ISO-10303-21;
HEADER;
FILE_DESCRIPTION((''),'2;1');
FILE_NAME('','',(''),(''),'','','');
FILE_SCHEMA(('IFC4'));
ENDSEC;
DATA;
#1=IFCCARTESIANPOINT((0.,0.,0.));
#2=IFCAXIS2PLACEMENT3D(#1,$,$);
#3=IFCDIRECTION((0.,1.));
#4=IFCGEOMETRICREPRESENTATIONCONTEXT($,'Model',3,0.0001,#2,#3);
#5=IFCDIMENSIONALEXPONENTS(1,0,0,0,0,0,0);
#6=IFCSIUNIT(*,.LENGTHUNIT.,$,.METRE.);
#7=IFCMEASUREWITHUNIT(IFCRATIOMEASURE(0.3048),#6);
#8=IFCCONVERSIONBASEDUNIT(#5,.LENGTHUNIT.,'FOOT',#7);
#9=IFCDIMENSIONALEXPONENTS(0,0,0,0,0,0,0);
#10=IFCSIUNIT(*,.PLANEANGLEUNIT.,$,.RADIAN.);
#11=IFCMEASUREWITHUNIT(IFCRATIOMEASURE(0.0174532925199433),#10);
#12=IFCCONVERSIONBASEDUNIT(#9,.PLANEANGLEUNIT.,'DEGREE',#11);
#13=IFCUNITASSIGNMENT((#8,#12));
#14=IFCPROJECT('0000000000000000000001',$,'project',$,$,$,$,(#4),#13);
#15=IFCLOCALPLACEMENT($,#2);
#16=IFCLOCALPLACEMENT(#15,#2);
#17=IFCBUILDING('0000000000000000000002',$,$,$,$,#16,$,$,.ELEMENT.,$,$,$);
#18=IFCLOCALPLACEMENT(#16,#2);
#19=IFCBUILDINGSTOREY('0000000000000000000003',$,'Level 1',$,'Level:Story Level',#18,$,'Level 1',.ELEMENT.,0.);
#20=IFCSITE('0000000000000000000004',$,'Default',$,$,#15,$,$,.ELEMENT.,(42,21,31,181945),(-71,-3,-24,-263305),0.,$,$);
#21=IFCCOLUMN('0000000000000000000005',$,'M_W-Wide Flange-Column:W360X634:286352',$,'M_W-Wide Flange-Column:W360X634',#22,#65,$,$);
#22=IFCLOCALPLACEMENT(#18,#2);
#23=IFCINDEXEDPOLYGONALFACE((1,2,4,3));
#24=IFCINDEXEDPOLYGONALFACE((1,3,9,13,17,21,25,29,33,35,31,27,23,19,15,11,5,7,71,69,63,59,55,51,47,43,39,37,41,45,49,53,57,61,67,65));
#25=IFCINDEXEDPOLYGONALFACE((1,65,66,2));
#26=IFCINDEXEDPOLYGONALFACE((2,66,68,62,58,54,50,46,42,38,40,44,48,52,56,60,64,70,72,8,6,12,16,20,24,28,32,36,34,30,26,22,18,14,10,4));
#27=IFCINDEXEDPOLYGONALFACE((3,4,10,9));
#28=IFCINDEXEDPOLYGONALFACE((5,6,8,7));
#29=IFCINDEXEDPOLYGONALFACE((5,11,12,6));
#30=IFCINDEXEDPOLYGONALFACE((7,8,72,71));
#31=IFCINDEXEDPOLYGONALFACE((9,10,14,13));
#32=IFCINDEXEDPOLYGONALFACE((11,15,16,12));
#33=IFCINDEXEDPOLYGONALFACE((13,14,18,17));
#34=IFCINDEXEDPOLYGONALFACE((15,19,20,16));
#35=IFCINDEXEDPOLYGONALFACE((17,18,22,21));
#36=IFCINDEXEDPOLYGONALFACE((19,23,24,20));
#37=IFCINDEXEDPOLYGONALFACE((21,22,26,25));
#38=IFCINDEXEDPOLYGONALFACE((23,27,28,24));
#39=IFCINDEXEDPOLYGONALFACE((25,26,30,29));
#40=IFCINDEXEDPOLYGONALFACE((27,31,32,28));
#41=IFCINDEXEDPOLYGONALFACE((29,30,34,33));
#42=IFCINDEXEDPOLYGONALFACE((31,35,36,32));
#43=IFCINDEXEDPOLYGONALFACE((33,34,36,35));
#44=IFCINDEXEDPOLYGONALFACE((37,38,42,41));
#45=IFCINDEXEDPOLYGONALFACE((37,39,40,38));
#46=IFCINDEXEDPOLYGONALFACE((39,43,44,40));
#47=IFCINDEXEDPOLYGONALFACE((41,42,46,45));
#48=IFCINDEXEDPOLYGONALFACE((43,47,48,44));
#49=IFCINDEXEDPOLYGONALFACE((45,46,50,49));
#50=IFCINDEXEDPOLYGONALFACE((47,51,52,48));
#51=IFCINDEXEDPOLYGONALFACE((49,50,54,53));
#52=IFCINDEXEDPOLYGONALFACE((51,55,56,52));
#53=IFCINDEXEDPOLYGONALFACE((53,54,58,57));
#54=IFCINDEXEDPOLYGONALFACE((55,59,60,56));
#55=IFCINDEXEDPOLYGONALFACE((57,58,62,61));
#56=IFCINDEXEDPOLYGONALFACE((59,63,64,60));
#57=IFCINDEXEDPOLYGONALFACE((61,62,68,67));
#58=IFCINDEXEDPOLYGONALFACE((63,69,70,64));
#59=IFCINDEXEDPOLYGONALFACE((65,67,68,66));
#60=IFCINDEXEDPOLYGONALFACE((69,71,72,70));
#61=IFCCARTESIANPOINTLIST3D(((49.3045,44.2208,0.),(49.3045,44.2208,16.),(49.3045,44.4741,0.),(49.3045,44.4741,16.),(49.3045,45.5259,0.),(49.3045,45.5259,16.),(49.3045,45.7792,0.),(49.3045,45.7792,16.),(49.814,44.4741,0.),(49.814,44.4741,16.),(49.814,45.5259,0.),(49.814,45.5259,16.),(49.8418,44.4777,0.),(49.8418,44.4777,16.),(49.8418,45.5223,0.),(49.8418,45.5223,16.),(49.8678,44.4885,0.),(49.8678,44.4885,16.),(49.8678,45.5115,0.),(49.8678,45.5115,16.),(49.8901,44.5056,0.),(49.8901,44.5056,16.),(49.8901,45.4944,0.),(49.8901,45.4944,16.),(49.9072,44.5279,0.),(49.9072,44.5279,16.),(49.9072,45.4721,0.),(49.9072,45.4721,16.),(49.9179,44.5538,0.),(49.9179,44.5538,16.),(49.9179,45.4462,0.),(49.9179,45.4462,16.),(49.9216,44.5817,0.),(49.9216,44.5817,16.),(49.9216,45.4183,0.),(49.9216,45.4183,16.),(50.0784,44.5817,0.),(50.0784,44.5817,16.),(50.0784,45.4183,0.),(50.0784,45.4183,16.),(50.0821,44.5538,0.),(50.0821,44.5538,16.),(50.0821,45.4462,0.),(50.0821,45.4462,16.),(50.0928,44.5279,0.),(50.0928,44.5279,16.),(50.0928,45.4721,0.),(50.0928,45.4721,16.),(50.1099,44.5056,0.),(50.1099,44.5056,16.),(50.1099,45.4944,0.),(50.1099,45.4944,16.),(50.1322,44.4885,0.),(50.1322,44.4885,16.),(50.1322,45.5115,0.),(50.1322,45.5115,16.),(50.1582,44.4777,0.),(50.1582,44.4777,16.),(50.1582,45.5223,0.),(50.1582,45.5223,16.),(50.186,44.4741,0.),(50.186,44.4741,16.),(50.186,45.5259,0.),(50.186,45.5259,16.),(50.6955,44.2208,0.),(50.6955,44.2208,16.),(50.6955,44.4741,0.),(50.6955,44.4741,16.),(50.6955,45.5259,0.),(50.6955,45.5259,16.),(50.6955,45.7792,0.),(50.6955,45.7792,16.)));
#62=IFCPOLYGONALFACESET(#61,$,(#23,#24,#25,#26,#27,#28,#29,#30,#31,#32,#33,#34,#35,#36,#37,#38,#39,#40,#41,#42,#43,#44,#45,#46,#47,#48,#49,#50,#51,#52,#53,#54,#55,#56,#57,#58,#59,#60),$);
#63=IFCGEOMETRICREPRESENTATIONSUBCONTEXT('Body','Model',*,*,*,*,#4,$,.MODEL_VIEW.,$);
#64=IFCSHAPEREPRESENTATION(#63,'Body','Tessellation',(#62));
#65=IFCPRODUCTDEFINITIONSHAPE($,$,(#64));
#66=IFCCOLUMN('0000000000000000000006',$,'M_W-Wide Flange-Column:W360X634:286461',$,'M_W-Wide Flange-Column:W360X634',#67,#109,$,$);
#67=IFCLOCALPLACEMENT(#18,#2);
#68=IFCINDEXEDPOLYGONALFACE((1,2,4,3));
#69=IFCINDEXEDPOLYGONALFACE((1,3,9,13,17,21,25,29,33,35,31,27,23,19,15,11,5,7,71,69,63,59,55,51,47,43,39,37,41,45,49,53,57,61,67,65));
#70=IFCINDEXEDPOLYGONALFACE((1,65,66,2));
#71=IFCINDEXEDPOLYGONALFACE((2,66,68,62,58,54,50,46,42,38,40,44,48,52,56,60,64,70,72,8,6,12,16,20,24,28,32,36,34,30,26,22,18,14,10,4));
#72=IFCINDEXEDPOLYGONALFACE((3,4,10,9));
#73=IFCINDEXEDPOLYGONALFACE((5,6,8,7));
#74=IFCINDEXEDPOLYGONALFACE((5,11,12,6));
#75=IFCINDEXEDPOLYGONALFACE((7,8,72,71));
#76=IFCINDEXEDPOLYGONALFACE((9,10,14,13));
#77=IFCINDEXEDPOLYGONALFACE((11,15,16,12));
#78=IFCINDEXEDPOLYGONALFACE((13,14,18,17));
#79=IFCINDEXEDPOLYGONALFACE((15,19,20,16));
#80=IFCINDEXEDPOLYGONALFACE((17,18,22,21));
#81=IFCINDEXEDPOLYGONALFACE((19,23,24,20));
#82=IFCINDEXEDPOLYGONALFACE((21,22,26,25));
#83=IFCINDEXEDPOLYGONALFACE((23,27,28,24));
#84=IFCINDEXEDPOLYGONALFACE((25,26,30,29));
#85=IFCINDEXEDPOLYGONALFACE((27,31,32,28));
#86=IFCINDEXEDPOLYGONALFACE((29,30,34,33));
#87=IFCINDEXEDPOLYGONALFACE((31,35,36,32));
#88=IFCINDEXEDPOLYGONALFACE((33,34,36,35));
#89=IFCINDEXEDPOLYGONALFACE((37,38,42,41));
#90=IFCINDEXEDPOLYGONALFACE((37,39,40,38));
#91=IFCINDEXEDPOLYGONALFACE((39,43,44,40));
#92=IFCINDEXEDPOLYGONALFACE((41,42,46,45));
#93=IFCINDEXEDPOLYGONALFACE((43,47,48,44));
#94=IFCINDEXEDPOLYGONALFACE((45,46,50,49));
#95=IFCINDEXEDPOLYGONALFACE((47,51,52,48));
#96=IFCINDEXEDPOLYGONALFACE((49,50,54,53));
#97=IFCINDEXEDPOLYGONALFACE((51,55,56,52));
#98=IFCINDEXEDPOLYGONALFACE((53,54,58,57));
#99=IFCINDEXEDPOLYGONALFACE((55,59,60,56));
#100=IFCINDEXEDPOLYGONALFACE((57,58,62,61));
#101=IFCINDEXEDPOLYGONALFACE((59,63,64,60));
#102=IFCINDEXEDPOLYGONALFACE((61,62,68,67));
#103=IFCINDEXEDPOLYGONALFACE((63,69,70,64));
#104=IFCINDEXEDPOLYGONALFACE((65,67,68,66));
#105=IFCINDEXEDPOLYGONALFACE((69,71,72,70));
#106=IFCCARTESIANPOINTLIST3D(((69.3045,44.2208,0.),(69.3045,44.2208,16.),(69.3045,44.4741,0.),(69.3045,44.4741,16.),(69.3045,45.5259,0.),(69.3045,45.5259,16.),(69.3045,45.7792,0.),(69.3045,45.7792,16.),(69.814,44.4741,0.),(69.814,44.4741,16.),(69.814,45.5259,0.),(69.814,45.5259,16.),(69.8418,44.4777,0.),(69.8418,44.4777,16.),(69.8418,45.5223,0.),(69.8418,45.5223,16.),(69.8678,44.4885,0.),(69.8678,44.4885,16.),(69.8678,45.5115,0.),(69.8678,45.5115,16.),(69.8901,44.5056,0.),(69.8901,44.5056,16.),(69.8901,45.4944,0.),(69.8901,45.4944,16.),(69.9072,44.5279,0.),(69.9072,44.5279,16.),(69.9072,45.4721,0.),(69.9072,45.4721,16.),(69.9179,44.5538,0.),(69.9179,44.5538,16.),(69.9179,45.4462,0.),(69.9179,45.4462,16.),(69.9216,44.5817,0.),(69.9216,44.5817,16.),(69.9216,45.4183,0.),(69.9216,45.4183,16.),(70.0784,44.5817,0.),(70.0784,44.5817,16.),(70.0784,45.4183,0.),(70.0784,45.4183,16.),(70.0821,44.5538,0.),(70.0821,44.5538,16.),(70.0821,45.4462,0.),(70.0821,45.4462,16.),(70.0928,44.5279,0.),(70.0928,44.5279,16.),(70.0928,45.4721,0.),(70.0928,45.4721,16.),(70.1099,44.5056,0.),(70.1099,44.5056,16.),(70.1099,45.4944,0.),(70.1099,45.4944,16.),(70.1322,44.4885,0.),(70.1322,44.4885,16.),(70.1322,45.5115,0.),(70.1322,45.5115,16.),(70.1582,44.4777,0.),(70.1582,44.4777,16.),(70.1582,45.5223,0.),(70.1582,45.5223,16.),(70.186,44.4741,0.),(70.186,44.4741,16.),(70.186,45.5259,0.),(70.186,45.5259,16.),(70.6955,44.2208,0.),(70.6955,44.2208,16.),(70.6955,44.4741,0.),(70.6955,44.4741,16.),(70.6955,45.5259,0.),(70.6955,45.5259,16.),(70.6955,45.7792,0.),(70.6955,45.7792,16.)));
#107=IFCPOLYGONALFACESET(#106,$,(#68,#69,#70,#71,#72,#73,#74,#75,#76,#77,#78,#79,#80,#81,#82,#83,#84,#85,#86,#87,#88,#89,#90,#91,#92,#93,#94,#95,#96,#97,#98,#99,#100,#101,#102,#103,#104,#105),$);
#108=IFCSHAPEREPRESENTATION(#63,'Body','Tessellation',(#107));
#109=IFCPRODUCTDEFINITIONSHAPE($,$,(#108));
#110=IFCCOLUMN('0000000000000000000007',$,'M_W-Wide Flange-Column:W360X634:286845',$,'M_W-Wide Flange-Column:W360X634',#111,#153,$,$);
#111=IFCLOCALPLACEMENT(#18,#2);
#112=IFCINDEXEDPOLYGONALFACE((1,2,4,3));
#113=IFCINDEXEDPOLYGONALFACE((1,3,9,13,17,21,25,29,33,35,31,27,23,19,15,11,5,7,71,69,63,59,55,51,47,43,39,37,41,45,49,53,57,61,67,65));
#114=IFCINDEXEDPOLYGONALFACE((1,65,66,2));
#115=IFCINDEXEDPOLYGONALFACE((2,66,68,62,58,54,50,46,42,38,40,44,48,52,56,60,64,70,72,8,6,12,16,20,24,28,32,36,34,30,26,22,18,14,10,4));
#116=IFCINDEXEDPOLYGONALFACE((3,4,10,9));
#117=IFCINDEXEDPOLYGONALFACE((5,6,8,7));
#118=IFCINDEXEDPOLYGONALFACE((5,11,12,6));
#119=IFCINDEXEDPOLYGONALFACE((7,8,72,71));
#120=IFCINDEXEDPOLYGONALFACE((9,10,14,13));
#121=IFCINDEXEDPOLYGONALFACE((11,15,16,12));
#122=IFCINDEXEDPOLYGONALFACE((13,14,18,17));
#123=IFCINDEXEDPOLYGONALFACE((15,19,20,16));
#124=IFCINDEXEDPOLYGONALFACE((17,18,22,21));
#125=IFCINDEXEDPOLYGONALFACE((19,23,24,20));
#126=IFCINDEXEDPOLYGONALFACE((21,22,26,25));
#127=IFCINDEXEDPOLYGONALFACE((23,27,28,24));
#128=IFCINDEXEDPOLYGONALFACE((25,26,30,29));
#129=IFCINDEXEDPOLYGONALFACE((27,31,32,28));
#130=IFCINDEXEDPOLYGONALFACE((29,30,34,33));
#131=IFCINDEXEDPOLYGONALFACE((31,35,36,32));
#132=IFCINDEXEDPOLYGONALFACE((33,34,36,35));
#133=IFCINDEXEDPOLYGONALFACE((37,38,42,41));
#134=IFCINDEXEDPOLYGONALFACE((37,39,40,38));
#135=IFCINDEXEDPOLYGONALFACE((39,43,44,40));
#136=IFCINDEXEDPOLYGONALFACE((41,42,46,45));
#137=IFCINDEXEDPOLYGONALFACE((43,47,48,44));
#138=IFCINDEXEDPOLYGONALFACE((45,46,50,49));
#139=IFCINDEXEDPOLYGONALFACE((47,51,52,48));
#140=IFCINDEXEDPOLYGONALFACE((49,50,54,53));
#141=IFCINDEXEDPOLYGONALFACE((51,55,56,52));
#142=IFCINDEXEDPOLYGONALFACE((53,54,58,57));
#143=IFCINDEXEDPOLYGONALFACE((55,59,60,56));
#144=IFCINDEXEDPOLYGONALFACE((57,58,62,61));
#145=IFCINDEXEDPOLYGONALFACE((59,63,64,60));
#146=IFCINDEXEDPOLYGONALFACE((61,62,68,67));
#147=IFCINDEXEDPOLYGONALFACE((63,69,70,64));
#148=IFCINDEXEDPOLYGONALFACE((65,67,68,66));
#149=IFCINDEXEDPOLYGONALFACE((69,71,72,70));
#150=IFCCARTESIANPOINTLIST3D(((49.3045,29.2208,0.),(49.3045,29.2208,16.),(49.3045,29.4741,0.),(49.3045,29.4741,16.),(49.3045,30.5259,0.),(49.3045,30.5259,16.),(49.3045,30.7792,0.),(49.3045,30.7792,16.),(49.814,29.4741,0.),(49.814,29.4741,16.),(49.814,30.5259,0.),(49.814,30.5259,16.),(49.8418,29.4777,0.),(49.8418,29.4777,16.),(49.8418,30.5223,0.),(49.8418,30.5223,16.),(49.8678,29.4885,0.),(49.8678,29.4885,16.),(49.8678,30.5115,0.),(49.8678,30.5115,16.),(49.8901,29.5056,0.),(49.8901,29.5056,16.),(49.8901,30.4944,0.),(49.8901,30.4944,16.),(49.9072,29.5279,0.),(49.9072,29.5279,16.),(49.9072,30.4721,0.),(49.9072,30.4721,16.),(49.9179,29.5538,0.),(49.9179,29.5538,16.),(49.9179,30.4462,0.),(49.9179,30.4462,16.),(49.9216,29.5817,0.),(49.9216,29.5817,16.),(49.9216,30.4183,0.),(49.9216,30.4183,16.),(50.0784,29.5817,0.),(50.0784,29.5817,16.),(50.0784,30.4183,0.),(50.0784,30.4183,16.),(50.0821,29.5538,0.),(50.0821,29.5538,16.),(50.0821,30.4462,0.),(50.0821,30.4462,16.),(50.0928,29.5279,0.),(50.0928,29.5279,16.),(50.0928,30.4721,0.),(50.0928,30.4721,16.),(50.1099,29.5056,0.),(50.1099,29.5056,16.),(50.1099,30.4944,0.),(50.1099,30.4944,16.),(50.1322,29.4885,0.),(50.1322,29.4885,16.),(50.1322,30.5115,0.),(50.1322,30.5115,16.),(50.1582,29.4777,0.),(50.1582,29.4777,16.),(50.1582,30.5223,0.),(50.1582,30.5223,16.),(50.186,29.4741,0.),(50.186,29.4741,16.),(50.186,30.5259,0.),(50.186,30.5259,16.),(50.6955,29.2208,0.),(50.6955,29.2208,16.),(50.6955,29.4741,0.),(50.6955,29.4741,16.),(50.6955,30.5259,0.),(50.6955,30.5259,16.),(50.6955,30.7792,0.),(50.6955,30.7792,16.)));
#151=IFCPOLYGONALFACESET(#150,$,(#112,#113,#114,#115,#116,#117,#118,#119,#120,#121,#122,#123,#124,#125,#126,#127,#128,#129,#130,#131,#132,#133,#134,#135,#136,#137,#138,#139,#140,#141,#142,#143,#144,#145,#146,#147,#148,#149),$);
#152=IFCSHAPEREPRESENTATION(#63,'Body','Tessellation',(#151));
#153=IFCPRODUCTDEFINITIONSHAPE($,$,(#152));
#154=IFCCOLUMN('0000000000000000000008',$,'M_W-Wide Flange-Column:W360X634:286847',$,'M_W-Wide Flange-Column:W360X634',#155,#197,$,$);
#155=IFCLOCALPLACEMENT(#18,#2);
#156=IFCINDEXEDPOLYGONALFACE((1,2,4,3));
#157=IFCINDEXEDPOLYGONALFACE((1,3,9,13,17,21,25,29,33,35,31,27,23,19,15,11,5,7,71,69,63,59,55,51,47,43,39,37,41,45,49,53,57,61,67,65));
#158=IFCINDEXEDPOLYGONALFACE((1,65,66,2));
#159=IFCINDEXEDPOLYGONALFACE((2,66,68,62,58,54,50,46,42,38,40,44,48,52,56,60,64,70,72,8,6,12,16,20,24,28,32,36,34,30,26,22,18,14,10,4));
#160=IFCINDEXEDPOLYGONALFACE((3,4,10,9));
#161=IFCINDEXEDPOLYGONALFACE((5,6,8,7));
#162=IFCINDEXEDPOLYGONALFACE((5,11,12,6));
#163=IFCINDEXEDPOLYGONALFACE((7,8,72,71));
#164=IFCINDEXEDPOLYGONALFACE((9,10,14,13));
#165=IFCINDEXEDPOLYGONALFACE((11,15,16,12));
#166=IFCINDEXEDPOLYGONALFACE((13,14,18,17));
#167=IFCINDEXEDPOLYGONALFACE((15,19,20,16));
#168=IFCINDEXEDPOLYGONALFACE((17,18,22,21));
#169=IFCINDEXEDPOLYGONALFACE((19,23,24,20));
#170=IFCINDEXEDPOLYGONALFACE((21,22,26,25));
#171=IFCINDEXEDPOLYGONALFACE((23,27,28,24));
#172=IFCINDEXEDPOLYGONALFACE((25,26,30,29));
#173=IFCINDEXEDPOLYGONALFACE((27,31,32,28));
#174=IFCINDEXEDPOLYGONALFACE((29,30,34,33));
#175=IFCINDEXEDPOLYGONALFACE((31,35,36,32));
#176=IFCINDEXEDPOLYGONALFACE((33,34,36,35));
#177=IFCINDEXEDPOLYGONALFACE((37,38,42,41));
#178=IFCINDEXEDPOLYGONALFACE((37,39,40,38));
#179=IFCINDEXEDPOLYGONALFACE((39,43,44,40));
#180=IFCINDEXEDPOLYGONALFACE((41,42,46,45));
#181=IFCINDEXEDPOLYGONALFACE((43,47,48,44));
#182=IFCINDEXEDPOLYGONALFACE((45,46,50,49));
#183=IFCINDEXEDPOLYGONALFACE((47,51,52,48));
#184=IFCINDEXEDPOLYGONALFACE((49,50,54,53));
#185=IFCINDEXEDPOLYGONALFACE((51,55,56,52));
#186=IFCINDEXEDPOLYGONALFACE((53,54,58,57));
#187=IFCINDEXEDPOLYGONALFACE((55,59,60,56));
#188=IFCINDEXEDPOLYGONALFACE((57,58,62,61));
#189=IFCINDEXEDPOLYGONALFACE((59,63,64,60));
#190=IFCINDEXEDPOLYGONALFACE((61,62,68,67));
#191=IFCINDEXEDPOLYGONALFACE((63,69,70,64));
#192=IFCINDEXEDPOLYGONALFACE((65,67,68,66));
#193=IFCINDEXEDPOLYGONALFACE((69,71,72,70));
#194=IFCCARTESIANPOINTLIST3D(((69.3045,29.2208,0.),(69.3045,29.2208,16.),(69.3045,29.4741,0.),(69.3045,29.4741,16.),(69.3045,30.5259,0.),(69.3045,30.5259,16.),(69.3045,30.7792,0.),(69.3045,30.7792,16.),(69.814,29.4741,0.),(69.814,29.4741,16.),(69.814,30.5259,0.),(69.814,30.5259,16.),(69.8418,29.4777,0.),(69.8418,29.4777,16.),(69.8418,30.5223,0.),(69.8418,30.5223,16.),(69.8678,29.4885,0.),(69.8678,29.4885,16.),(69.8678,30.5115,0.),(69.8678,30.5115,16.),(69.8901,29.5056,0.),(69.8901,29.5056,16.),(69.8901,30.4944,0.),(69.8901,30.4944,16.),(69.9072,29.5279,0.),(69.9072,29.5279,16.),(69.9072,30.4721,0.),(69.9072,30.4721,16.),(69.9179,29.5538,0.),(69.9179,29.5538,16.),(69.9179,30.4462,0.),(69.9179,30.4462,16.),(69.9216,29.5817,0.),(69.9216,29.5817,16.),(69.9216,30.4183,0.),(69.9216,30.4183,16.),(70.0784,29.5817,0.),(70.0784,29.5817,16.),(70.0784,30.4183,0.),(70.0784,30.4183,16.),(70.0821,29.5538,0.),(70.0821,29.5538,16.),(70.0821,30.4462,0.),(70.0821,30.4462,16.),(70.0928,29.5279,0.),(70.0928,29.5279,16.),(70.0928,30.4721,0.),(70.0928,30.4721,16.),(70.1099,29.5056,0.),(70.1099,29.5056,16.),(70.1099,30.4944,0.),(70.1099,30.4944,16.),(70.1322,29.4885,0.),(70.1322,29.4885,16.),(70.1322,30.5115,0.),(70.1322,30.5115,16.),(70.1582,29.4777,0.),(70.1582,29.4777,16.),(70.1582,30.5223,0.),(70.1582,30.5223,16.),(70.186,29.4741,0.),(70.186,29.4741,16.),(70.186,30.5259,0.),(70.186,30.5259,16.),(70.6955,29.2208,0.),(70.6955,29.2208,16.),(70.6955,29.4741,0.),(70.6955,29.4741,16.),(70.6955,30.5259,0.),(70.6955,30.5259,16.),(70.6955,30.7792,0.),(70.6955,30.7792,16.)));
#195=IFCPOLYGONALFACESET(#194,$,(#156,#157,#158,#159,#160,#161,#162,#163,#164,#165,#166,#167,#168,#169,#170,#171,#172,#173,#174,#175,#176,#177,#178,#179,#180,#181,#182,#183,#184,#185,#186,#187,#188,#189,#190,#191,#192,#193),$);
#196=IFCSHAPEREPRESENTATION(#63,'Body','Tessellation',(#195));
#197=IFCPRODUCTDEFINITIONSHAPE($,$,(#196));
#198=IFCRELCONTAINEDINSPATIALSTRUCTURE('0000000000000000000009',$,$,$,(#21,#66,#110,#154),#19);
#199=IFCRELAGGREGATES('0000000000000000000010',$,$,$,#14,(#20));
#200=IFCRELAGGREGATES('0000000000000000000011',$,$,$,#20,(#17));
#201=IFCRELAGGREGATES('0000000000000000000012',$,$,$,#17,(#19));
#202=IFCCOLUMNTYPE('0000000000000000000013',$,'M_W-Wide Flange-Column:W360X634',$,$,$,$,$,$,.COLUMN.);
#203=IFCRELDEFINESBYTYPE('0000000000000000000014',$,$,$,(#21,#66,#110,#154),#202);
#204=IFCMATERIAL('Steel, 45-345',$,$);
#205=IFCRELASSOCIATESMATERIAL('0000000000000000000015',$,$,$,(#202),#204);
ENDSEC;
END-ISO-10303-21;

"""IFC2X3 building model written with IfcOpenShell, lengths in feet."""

from ifc_helpers import new_model, entity, si_unit, converted_unit, direction, frame, frame_2d, origin, place, context, subcontext, project, spatial, polyline, circle_curve, parameter, trimmed, segment, composite_curve, outline, extrude, source, transform, mapped, material, type_object, type_shapes, element, save


model = new_model("IFC2X3")

# Units and contexts
model_context = context("Model", 3, precision=0.0001, world=origin(), true_north=direction((0.0, 1.0)))
body_context = subcontext(model_context, "Body", "Model", "MODEL_VIEW")
ifc_project = project(units=[converted_unit("LENGTHUNIT", "FOOT", entity("IfcRatioMeasure", 0.3048), si_unit("LENGTHUNIT", "METRE"), dimensions=[1, 0, 0, 0, 0, 0, 0]), converted_unit("PLANEANGLEUNIT", "DEGREE", entity("IfcRatioMeasure", 0.0174532925199433), si_unit("PLANEANGLEUNIT", "RADIAN"), dimensions=[0, 0, 0, 0, 0, 0, 0])], contexts=[model_context])

# Site, building, storey
site_placement = place(None, origin())
site = spatial("IfcSite", under=ifc_project, at=site_placement, Name="Default", CompositionType="ELEMENT", RefLatitude=(42, 21, 31, 181945), RefLongitude=(-71, -3, -24, -263305), RefElevation=0.0)
building_placement = place(site_placement, origin())
building = spatial("IfcBuilding", under=site, at=building_placement, CompositionType="ELEMENT")
storey_placement = place(building_placement, origin())
storey = spatial("IfcBuildingStorey", under=building, at=storey_placement, Name="Level 1", ObjectType="Level:Story Level", LongName="Level 1", CompositionType="ELEMENT", Elevation=0.0)

# Columns
ifc_material = material(Name="Steel, 45-345")
column_type = type_object("IfcColumnType", Name="M_W-Wide Flange-Column:W360X634", PredefinedType="COLUMN", material=ifc_material)
shared_shape = source(origin(), body_context, "Body", "SweptSolid", [
    extrude(outline(composite_curve([segment(polyline([(0.5259, -0.6955), (0.7792, -0.6955)]), True, "CONTINUOUS"), segment(polyline([(0.7792, -0.6955), (0.7792, 0.6955)]), True, "CONTINUOUS"), segment(polyline([(0.7792, 0.6955), (0.5259, 0.6955)]), True, "CONTINUOUS"), segment(polyline([(0.5259, 0.6955), (0.5259, 0.186)]), True, "CONTINUOUS"), segment(trimmed(circle_curve(frame_2d((0.4183, 0.186), x_axis=(1.0, 0.0)), 0.1076), [parameter(270.0)], [parameter(0.0)], True, "PARAMETER"), False, "CONTINUOUS"), segment(polyline([(0.4183, 0.0784), (-0.4183, 0.0784)]), True, "CONTINUOUS"), segment(trimmed(circle_curve(frame_2d((-0.4183, 0.186), x_axis=(0.0, -1.0)), 0.1076), [parameter(270.0)], [parameter(0.0)], True, "PARAMETER"), False, "CONTINUOUS"), segment(polyline([(-0.5259, 0.186), (-0.5259, 0.6955)]), True, "CONTINUOUS"), segment(polyline([(-0.5259, 0.6955), (-0.7792, 0.6955)]), True, "CONTINUOUS"), segment(polyline([(-0.7792, 0.6955), (-0.7792, -0.6955)]), True, "CONTINUOUS"), segment(polyline([(-0.7792, -0.6955), (-0.5259, -0.6955)]), True, "CONTINUOUS"), segment(polyline([(-0.5259, -0.6955), (-0.5259, -0.186)]), True, "CONTINUOUS"), segment(trimmed(circle_curve(frame_2d((-0.4183, -0.186), x_axis=(-1.0, 0.0)), 0.1076), [parameter(270.0)], [parameter(0.0)], True, "PARAMETER"), False, "CONTINUOUS"), segment(polyline([(-0.4183, -0.0784), (0.4183, -0.0784)]), True, "CONTINUOUS"), segment(trimmed(circle_curve(frame_2d((0.4183, -0.186), x_axis=(0.0, 1.0)), 0.1076), [parameter(270.0)], [parameter(0.0)], True, "PARAMETER"), False, "CONTINUOUS"), segment(polyline([(0.5259, -0.186), (0.5259, -0.6955)]), True, "CONTINUOUS")], self_intersect=False)), frame((0.0, 0.0, 0.0), z_axis=(0.0, 0.0, 1.0), x_axis=(0.0, -1.0, 0.0)), (0.0, 0.0, 1.0), 16.0),
])
type_shapes(column_type, [shared_shape])
for number, where, name in (
    (1, (50.0, 45.0, 0.0), "M_W-Wide Flange-Column:W360X634:286352"),
    (2, (70.0, 45.0, 0.0), "M_W-Wide Flange-Column:W360X634:286461"),
    (3, (50.0, 30.0, 0.0), "M_W-Wide Flange-Column:W360X634:286845"),
    (4, (70.0, 30.0, 0.0), "M_W-Wide Flange-Column:W360X634:286847"),
):
    element("IfcColumn", number, at=place(storey_placement, frame(where)), inside=storey, type_object=column_type, Name=name, ObjectType="M_W-Wide Flange-Column:W360X634", context=body_context, shape_type="MappedRepresentation", body=[
        mapped(shared_shape, transform((0.0, 0.0, 0.0), scale=1.0)),
    ])

save(model, "model.ifc")
